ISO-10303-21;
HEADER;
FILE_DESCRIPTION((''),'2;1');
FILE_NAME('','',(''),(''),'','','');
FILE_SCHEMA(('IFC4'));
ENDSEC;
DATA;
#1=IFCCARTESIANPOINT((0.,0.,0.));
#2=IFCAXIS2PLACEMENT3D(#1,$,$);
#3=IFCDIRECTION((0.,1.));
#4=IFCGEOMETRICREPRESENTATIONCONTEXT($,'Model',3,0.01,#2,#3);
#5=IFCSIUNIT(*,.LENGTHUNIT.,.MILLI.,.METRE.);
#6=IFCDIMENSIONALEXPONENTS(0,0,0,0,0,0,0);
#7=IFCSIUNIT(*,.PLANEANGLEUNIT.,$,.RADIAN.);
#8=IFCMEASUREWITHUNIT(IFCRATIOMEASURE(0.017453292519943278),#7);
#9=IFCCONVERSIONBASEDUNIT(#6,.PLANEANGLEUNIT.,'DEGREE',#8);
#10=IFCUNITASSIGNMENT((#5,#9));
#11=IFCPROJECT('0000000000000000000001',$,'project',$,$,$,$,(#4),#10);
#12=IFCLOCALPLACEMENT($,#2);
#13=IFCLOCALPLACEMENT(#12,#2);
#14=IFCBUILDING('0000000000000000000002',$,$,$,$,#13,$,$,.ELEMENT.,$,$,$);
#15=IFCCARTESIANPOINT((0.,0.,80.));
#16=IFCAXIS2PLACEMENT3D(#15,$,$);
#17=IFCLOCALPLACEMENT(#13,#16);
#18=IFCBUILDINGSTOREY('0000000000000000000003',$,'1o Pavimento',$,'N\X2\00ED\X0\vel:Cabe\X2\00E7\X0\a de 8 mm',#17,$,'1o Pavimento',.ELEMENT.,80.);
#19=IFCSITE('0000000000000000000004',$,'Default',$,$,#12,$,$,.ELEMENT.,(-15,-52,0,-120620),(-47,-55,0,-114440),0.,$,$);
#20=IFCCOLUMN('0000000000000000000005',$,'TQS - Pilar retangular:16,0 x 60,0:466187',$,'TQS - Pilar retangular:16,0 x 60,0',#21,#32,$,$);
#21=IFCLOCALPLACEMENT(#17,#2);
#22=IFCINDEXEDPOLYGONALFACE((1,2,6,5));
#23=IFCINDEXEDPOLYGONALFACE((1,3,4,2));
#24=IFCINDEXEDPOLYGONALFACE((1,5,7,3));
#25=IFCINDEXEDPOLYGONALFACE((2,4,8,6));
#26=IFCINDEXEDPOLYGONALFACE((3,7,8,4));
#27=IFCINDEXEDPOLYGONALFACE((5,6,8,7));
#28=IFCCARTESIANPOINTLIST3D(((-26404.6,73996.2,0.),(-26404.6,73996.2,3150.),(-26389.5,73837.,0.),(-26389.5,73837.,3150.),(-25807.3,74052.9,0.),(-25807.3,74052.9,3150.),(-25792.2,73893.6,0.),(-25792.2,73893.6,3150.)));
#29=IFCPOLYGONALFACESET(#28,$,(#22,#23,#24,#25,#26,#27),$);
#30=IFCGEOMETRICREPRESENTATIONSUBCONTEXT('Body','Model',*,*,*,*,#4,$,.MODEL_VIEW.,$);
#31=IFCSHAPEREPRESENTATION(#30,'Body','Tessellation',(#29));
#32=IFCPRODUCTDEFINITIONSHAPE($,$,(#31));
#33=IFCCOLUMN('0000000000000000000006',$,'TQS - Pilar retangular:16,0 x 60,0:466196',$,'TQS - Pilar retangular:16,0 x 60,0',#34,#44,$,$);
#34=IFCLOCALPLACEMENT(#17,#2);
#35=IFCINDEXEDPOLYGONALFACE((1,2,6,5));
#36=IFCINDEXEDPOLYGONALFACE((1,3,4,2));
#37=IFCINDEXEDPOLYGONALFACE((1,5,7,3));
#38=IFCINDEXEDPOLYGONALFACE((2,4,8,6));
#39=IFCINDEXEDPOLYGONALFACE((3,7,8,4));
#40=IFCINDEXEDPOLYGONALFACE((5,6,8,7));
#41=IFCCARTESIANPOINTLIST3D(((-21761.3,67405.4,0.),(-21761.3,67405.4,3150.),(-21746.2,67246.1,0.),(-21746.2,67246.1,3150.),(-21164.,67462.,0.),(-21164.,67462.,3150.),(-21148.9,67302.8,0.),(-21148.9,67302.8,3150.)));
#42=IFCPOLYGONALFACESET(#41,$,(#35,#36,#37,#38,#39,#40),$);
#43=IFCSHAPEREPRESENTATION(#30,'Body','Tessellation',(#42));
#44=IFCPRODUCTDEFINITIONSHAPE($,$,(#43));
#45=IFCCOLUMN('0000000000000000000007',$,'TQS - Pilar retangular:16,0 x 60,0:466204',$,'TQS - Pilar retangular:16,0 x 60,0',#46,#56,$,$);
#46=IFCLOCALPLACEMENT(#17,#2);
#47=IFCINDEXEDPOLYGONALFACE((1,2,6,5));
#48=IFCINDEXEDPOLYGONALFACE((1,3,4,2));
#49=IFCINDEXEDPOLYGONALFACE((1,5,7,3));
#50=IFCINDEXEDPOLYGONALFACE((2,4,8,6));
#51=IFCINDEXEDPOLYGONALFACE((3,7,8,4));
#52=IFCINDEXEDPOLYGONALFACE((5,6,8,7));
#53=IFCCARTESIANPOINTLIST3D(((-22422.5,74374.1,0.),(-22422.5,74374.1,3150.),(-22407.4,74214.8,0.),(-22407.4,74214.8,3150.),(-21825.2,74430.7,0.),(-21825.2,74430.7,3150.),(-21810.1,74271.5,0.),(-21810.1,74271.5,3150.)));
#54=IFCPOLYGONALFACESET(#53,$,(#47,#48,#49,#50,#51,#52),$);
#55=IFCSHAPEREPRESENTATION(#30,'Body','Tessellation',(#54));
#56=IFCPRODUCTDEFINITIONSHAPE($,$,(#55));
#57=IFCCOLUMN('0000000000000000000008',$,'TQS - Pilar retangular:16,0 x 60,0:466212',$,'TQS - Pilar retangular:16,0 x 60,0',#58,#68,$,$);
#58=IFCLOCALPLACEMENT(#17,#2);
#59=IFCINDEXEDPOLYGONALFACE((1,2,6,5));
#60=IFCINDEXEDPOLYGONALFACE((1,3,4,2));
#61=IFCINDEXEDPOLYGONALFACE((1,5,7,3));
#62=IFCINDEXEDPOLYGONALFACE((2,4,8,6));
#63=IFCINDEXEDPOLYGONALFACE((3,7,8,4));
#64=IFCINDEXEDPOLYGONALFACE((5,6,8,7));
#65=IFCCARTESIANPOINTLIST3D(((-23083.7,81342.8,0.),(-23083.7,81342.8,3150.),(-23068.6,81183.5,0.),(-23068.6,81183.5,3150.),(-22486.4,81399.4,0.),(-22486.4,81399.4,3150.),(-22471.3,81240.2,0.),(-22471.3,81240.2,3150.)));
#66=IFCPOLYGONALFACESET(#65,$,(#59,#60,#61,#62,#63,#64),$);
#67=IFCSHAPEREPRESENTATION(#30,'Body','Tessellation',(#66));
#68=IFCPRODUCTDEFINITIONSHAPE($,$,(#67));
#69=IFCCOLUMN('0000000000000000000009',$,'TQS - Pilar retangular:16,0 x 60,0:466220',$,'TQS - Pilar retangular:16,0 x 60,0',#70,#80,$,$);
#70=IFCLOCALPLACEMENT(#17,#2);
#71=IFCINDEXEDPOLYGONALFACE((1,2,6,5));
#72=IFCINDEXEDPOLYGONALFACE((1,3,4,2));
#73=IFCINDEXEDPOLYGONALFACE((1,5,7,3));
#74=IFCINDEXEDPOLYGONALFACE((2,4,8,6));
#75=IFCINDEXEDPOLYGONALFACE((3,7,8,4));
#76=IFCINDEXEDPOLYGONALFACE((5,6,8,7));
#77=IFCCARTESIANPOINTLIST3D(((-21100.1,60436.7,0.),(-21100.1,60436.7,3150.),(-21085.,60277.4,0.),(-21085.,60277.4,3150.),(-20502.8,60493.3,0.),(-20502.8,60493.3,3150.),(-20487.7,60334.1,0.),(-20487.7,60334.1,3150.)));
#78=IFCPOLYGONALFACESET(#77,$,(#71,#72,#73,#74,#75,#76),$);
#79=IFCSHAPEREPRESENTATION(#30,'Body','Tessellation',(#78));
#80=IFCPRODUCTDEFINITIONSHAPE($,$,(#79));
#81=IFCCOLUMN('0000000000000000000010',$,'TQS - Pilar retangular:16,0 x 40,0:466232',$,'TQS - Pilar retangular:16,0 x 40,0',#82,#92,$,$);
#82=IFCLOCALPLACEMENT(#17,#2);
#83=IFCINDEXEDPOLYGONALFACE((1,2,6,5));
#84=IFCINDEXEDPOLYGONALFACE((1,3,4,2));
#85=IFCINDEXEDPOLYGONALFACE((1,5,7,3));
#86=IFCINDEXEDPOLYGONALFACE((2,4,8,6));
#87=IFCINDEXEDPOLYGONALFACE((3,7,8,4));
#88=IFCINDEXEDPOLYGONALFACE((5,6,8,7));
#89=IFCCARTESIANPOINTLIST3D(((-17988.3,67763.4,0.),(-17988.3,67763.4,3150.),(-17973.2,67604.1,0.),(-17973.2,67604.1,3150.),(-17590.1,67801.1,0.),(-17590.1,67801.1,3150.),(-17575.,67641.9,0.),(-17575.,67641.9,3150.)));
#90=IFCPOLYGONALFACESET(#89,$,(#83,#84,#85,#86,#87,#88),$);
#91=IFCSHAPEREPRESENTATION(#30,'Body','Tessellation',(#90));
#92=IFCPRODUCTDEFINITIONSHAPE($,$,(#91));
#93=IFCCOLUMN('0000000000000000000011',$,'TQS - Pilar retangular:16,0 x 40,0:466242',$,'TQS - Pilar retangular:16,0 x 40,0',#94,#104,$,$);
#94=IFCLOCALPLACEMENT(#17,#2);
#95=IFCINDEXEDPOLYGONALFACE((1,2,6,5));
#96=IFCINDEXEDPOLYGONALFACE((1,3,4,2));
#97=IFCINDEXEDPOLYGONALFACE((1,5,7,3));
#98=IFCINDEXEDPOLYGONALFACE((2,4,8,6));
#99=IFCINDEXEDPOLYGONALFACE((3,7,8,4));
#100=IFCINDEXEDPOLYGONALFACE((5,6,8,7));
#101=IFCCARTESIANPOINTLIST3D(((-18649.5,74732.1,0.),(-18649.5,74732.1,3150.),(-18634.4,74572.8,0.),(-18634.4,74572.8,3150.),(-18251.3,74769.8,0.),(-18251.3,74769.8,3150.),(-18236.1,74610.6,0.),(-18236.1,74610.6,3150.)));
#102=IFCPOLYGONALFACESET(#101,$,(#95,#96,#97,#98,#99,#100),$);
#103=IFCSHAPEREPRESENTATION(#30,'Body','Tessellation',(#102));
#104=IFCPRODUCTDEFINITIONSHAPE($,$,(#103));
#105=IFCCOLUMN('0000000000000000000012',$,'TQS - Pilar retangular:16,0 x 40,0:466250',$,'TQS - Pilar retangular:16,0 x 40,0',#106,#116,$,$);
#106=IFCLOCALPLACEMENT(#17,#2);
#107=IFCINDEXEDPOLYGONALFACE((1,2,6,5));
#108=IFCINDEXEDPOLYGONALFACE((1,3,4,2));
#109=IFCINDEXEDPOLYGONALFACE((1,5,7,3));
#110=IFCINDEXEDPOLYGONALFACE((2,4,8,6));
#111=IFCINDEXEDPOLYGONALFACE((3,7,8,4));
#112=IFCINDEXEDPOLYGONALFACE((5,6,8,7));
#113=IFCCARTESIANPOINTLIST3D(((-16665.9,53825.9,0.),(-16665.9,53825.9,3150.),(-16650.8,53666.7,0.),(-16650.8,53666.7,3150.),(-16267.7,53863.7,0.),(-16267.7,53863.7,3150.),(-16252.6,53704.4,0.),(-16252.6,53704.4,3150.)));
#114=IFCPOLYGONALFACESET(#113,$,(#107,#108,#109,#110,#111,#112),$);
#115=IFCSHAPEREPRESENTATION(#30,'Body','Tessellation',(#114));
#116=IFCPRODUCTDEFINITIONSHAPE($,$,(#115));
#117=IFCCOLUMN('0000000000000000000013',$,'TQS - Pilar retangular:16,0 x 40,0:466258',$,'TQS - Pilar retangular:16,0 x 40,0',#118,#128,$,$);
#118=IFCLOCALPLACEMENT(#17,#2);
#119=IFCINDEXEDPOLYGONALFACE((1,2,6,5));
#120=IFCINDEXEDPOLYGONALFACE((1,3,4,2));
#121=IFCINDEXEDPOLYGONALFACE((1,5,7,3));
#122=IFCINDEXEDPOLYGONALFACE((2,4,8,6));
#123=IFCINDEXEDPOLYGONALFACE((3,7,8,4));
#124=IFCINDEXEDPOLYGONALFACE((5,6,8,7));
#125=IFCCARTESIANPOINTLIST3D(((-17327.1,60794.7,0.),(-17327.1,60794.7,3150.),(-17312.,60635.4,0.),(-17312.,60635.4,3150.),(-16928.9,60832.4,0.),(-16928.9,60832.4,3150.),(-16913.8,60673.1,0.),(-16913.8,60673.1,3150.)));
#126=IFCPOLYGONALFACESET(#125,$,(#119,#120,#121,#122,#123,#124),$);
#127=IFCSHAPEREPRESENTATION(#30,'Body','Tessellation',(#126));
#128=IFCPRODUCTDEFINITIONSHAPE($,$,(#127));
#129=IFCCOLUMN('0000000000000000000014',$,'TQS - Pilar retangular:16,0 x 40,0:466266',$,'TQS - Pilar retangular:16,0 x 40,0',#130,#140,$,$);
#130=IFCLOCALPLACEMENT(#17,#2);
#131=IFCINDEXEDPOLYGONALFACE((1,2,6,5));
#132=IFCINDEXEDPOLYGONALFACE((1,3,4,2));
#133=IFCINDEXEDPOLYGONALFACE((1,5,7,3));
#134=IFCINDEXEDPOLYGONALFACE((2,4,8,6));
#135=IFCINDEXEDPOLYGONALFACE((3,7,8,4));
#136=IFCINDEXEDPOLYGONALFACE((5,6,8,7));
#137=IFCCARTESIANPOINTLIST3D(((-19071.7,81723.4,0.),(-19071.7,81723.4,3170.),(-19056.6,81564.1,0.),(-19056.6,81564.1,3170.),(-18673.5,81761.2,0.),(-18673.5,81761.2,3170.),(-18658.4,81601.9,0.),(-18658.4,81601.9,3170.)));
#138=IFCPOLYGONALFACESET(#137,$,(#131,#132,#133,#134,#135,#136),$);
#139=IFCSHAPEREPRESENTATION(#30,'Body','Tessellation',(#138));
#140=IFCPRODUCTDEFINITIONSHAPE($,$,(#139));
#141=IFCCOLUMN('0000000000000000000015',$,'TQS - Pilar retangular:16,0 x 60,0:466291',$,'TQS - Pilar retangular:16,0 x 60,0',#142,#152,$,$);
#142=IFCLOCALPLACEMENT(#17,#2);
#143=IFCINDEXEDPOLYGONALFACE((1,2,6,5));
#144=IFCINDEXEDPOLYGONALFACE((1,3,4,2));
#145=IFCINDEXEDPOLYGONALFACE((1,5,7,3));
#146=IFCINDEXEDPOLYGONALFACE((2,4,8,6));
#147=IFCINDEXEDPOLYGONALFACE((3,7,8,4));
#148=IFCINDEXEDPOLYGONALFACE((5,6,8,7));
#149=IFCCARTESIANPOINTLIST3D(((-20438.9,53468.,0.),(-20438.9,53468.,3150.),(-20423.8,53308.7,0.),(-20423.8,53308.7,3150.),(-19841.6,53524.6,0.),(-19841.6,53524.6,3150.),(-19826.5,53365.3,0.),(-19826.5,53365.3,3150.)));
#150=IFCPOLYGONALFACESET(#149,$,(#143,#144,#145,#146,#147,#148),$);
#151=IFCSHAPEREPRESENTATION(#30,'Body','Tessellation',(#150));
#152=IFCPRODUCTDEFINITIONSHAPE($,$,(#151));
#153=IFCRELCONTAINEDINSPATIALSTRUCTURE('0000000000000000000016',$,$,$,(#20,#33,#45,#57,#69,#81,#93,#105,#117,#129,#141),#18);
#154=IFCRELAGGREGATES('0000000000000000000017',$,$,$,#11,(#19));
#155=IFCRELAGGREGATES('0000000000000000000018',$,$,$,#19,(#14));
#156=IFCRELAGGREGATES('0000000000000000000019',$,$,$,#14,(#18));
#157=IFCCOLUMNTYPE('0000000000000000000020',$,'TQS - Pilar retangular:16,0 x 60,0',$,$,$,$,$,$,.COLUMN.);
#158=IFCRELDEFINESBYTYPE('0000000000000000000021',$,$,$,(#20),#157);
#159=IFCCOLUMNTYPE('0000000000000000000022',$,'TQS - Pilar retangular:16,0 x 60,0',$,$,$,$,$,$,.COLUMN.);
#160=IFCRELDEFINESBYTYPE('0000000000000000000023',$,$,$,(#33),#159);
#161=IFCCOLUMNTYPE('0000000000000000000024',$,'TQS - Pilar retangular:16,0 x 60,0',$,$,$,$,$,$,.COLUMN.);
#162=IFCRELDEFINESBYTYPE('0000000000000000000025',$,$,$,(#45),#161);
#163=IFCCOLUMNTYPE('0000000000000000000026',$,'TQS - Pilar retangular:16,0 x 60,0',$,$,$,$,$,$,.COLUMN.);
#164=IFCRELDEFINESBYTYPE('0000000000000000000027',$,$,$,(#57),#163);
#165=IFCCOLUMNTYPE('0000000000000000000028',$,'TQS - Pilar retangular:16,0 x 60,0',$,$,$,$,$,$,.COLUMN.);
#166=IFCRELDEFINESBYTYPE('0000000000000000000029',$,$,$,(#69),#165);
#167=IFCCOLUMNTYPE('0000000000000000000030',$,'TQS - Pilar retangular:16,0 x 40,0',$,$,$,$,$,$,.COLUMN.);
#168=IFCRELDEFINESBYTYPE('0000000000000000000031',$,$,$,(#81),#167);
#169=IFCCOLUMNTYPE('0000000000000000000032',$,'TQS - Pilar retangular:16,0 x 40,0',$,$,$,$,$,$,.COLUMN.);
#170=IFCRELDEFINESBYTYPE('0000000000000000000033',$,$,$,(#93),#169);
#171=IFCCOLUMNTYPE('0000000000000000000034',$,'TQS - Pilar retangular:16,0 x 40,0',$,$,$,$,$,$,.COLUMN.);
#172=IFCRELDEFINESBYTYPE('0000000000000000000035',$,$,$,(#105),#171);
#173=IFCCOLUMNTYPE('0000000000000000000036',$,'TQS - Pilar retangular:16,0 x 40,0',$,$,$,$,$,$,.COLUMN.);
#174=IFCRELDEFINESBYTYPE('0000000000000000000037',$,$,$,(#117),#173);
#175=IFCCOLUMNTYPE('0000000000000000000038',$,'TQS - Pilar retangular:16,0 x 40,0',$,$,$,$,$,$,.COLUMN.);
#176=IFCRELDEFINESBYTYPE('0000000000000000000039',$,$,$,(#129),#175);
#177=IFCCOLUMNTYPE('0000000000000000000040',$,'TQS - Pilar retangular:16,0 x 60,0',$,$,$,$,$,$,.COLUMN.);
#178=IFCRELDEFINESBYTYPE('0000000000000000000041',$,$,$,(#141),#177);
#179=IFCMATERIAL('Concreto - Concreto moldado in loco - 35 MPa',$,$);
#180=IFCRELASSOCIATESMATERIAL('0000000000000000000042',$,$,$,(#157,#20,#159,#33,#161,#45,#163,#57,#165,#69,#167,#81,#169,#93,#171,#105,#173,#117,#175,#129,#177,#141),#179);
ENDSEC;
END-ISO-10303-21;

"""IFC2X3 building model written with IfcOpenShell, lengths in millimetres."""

from ifc_helpers import new_model, entity, si_unit, converted_unit, direction, frame, origin, origin_2d_with_axis, place, context, subcontext, project, spatial, rectangle, extrude, source, transform, mapped, material, type_object, type_shapes, element, save


model = new_model("IFC2X3")

# Units and contexts
model_context = context("Model", 3, precision=0.01, world=origin(), true_north=direction((0.0, 1.0)))
body_context = subcontext(model_context, "Body", "Model", "MODEL_VIEW")
ifc_project = project(units=[si_unit("LENGTHUNIT", "METRE", prefix="MILLI"), converted_unit("PLANEANGLEUNIT", "DEGREE", entity("IfcRatioMeasure", 0.017453292519943278), si_unit("PLANEANGLEUNIT", "RADIAN"), dimensions=[0, 0, 0, 0, 0, 0, 0])], contexts=[model_context])

# Site, building, storey
site_placement = place(None, origin())
site = spatial("IfcSite", under=ifc_project, at=site_placement, Name="Default", CompositionType="ELEMENT", RefLatitude=(-15, -52, 0, -120620), RefLongitude=(-47, -55, 0, -114440), RefElevation=0.0)
building_placement = place(site_placement, origin())
building = spatial("IfcBuilding", under=site, at=building_placement, CompositionType="ELEMENT")
storey_placement = place(building_placement, frame((0.0, 0.0, 80.0)))
storey = spatial("IfcBuildingStorey", under=building, at=storey_placement, Name="1o Pavimento", ObjectType="Nível:Cabeça de 8 mm", LongName="1o Pavimento", CompositionType="ELEMENT", Elevation=80.0)

# Columns
ifc_material = material(Name="Concreto - Concreto moldado in loco - 35 MPa")
column_type_1 = type_object("IfcColumnType", Name="TQS - Pilar retangular:16,0 x 60,0", PredefinedType="COLUMN", material=ifc_material)
shared_shape_1 = source(origin(), body_context, "Body", "SweptSolid", [
    extrude(rectangle(XDim=600.0, YDim=160.0, at=origin_2d_with_axis()), frame((-26098.4, 73944.9, 80.0), z_axis=(0.0, 0.0, 1.0), x_axis=(-0.995529, -0.094456, 0.0)), (0.0, 0.0, 1.0), 3150.0),
])
type_shapes(column_type_1, [shared_shape_1])
column_1_placement = place(storey_placement, frame((0.0, 0.0, -80.0)))
element("IfcColumn", 1, at=column_1_placement, inside=storey, type_object=column_type_1, material=ifc_material, Name="TQS - Pilar retangular:16,0 x 60,0:466187", ObjectType="TQS - Pilar retangular:16,0 x 60,0", context=body_context, shape_type="MappedRepresentation", body=[
    mapped(shared_shape_1, transform((0.0, 0.0, 0.0), scale=1.0)),
])
column_type_2 = type_object("IfcColumnType", Name="TQS - Pilar retangular:16,0 x 60,0", PredefinedType="COLUMN", material=ifc_material)
shared_shape_2 = source(origin(), body_context, "Body", "SweptSolid", [
    extrude(rectangle(XDim=600.0, YDim=160.0, at=origin_2d_with_axis()), frame((-21455.1, 67354.1, 80.0), z_axis=(0.0, 0.0, 1.0), x_axis=(-0.995529, -0.094456, 0.0)), (0.0, 0.0, 1.0), 3150.0),
])
type_shapes(column_type_2, [shared_shape_2])
column_2_placement = place(storey_placement, frame((0.0, 0.0, -80.0)))
element("IfcColumn", 2, at=column_2_placement, inside=storey, type_object=column_type_2, material=ifc_material, Name="TQS - Pilar retangular:16,0 x 60,0:466196", ObjectType="TQS - Pilar retangular:16,0 x 60,0", context=body_context, shape_type="MappedRepresentation", body=[
    mapped(shared_shape_2, transform((0.0, 0.0, 0.0), scale=1.0)),
])
column_type_3 = type_object("IfcColumnType", Name="TQS - Pilar retangular:16,0 x 60,0", PredefinedType="COLUMN", material=ifc_material)
shared_shape_3 = source(origin(), body_context, "Body", "SweptSolid", [
    extrude(rectangle(XDim=600.0, YDim=160.0, at=origin_2d_with_axis()), frame((-22116.3, 74322.8, 80.0), z_axis=(0.0, 0.0, 1.0), x_axis=(-0.995529, -0.094456, 0.0)), (0.0, 0.0, 1.0), 3150.0),
])
type_shapes(column_type_3, [shared_shape_3])
column_3_placement = place(storey_placement, frame((0.0, 0.0, -80.0)))
element("IfcColumn", 3, at=column_3_placement, inside=storey, type_object=column_type_3, material=ifc_material, Name="TQS - Pilar retangular:16,0 x 60,0:466204", ObjectType="TQS - Pilar retangular:16,0 x 60,0", context=body_context, shape_type="MappedRepresentation", body=[
    mapped(shared_shape_3, transform((0.0, 0.0, 0.0), scale=1.0)),
])
column_type_4 = type_object("IfcColumnType", Name="TQS - Pilar retangular:16,0 x 60,0", PredefinedType="COLUMN", material=ifc_material)
shared_shape_4 = source(origin(), body_context, "Body", "SweptSolid", [
    extrude(rectangle(XDim=600.0, YDim=160.0, at=origin_2d_with_axis()), frame((-22777.5, 81291.5, 80.0), z_axis=(0.0, 0.0, 1.0), x_axis=(-0.995529, -0.094456, 0.0)), (0.0, 0.0, 1.0), 3150.0),
])
type_shapes(column_type_4, [shared_shape_4])
column_4_placement = place(storey_placement, frame((0.0, 0.0, -80.0)))
element("IfcColumn", 4, at=column_4_placement, inside=storey, type_object=column_type_4, material=ifc_material, Name="TQS - Pilar retangular:16,0 x 60,0:466212", ObjectType="TQS - Pilar retangular:16,0 x 60,0", context=body_context, shape_type="MappedRepresentation", body=[
    mapped(shared_shape_4, transform((0.0, 0.0, 0.0), scale=1.0)),
])
column_type_5 = type_object("IfcColumnType", Name="TQS - Pilar retangular:16,0 x 60,0", PredefinedType="COLUMN", material=ifc_material)
shared_shape_5 = source(origin(), body_context, "Body", "SweptSolid", [
    extrude(rectangle(XDim=600.0, YDim=160.0, at=origin_2d_with_axis()), frame((-20793.9, 60385.4, 80.0), z_axis=(0.0, 0.0, 1.0), x_axis=(-0.995529, -0.094456, 0.0)), (0.0, 0.0, 1.0), 3150.0),
])
type_shapes(column_type_5, [shared_shape_5])
column_5_placement = place(storey_placement, frame((0.0, 0.0, -80.0)))
element("IfcColumn", 5, at=column_5_placement, inside=storey, type_object=column_type_5, material=ifc_material, Name="TQS - Pilar retangular:16,0 x 60,0:466220", ObjectType="TQS - Pilar retangular:16,0 x 60,0", context=body_context, shape_type="MappedRepresentation", body=[
    mapped(shared_shape_5, transform((0.0, 0.0, 0.0), scale=1.0)),
])
column_type_6 = type_object("IfcColumnType", Name="TQS - Pilar retangular:16,0 x 40,0", PredefinedType="COLUMN", material=ifc_material)
shared_shape_6 = source(origin(), body_context, "Body", "SweptSolid", [
    extrude(rectangle(XDim=400.0, YDim=160.0, at=origin_2d_with_axis()), frame((-17781.6, 67702.6, 80.0), z_axis=(0.0, 0.0, 1.0), x_axis=(-0.995529, -0.094456, 0.0)), (0.0, 0.0, 1.0), 3150.0),
])
type_shapes(column_type_6, [shared_shape_6])
column_6_placement = place(storey_placement, frame((0.0, 0.0, -80.0)))
element("IfcColumn", 6, at=column_6_placement, inside=storey, type_object=column_type_6, material=ifc_material, Name="TQS - Pilar retangular:16,0 x 40,0:466232", ObjectType="TQS - Pilar retangular:16,0 x 40,0", context=body_context, shape_type="MappedRepresentation", body=[
    mapped(shared_shape_6, transform((0.0, 0.0, 0.0), scale=1.0)),
])
column_type_7 = type_object("IfcColumnType", Name="TQS - Pilar retangular:16,0 x 40,0", PredefinedType="COLUMN", material=ifc_material)
shared_shape_7 = source(origin(), body_context, "Body", "SweptSolid", [
    extrude(rectangle(XDim=400.0, YDim=160.0, at=origin_2d_with_axis()), frame((-18442.8, 74671.3, 80.0), z_axis=(0.0, 0.0, 1.0), x_axis=(-0.995529, -0.094456, 0.0)), (0.0, 0.0, 1.0), 3150.0),
])
type_shapes(column_type_7, [shared_shape_7])
column_7_placement = place(storey_placement, frame((0.0, 0.0, -80.0)))
element("IfcColumn", 7, at=column_7_placement, inside=storey, type_object=column_type_7, material=ifc_material, Name="TQS - Pilar retangular:16,0 x 40,0:466242", ObjectType="TQS - Pilar retangular:16,0 x 40,0", context=body_context, shape_type="MappedRepresentation", body=[
    mapped(shared_shape_7, transform((0.0, 0.0, 0.0), scale=1.0)),
])
column_type_8 = type_object("IfcColumnType", Name="TQS - Pilar retangular:16,0 x 40,0", PredefinedType="COLUMN", material=ifc_material)
shared_shape_8 = source(origin(), body_context, "Body", "SweptSolid", [
    extrude(rectangle(XDim=400.0, YDim=160.0, at=origin_2d_with_axis()), frame((-16459.2, 53765.2, 80.0), z_axis=(0.0, 0.0, 1.0), x_axis=(-0.995529, -0.094456, 0.0)), (0.0, 0.0, 1.0), 3150.0),
])
type_shapes(column_type_8, [shared_shape_8])
column_8_placement = place(storey_placement, frame((0.0, 0.0, -80.0)))
element("IfcColumn", 8, at=column_8_placement, inside=storey, type_object=column_type_8, material=ifc_material, Name="TQS - Pilar retangular:16,0 x 40,0:466250", ObjectType="TQS - Pilar retangular:16,0 x 40,0", context=body_context, shape_type="MappedRepresentation", body=[
    mapped(shared_shape_8, transform((0.0, 0.0, 0.0), scale=1.0)),
])
column_type_9 = type_object("IfcColumnType", Name="TQS - Pilar retangular:16,0 x 40,0", PredefinedType="COLUMN", material=ifc_material)
shared_shape_9 = source(origin(), body_context, "Body", "SweptSolid", [
    extrude(rectangle(XDim=400.0, YDim=160.0, at=origin_2d_with_axis()), frame((-17120.4, 60733.9, 80.0), z_axis=(0.0, 0.0, 1.0), x_axis=(-0.995529, -0.094456, 0.0)), (0.0, 0.0, 1.0), 3150.0),
])
type_shapes(column_type_9, [shared_shape_9])
column_9_placement = place(storey_placement, frame((0.0, 0.0, -80.0)))
element("IfcColumn", 9, at=column_9_placement, inside=storey, type_object=column_type_9, material=ifc_material, Name="TQS - Pilar retangular:16,0 x 40,0:466258", ObjectType="TQS - Pilar retangular:16,0 x 40,0", context=body_context, shape_type="MappedRepresentation", body=[
    mapped(shared_shape_9, transform((0.0, 0.0, 0.0), scale=1.0)),
])
column_type_10 = type_object("IfcColumnType", Name="TQS - Pilar retangular:16,0 x 40,0", PredefinedType="COLUMN", material=ifc_material)
shared_shape_10 = source(origin(), body_context, "Body", "SweptSolid", [
    extrude(rectangle(XDim=400.0, YDim=160.0, at=origin_2d_with_axis()), frame((-18865.1, 81662.7, 80.0), z_axis=(0.0, 0.0, 1.0), x_axis=(-0.995529, -0.094456, 0.0)), (0.0, 0.0, 1.0), 3170.0),
])
type_shapes(column_type_10, [shared_shape_10])
column_10_placement = place(storey_placement, frame((0.0, 0.0, -80.0)))
element("IfcColumn", 10, at=column_10_placement, inside=storey, type_object=column_type_10, material=ifc_material, Name="TQS - Pilar retangular:16,0 x 40,0:466266", ObjectType="TQS - Pilar retangular:16,0 x 40,0", context=body_context, shape_type="MappedRepresentation", body=[
    mapped(shared_shape_10, transform((0.0, 0.0, 0.0), scale=1.0)),
])
column_type_11 = type_object("IfcColumnType", Name="TQS - Pilar retangular:16,0 x 60,0", PredefinedType="COLUMN", material=ifc_material)
shared_shape_11 = source(origin(), body_context, "Body", "SweptSolid", [
    extrude(rectangle(XDim=600.0, YDim=160.0, at=origin_2d_with_axis()), frame((-20132.7, 53416.7, 80.0), z_axis=(0.0, 0.0, 1.0), x_axis=(-0.995529, -0.094456, 0.0)), (0.0, 0.0, 1.0), 3150.0),
])
type_shapes(column_type_11, [shared_shape_11])
column_11_placement = place(storey_placement, frame((0.0, 0.0, -80.0)))
element("IfcColumn", 11, at=column_11_placement, inside=storey, type_object=column_type_11, material=ifc_material, Name="TQS - Pilar retangular:16,0 x 60,0:466291", ObjectType="TQS - Pilar retangular:16,0 x 60,0", context=body_context, shape_type="MappedRepresentation", body=[
    mapped(shared_shape_11, transform((0.0, 0.0, 0.0), scale=1.0)),
])

save(model, "model.ifc")
